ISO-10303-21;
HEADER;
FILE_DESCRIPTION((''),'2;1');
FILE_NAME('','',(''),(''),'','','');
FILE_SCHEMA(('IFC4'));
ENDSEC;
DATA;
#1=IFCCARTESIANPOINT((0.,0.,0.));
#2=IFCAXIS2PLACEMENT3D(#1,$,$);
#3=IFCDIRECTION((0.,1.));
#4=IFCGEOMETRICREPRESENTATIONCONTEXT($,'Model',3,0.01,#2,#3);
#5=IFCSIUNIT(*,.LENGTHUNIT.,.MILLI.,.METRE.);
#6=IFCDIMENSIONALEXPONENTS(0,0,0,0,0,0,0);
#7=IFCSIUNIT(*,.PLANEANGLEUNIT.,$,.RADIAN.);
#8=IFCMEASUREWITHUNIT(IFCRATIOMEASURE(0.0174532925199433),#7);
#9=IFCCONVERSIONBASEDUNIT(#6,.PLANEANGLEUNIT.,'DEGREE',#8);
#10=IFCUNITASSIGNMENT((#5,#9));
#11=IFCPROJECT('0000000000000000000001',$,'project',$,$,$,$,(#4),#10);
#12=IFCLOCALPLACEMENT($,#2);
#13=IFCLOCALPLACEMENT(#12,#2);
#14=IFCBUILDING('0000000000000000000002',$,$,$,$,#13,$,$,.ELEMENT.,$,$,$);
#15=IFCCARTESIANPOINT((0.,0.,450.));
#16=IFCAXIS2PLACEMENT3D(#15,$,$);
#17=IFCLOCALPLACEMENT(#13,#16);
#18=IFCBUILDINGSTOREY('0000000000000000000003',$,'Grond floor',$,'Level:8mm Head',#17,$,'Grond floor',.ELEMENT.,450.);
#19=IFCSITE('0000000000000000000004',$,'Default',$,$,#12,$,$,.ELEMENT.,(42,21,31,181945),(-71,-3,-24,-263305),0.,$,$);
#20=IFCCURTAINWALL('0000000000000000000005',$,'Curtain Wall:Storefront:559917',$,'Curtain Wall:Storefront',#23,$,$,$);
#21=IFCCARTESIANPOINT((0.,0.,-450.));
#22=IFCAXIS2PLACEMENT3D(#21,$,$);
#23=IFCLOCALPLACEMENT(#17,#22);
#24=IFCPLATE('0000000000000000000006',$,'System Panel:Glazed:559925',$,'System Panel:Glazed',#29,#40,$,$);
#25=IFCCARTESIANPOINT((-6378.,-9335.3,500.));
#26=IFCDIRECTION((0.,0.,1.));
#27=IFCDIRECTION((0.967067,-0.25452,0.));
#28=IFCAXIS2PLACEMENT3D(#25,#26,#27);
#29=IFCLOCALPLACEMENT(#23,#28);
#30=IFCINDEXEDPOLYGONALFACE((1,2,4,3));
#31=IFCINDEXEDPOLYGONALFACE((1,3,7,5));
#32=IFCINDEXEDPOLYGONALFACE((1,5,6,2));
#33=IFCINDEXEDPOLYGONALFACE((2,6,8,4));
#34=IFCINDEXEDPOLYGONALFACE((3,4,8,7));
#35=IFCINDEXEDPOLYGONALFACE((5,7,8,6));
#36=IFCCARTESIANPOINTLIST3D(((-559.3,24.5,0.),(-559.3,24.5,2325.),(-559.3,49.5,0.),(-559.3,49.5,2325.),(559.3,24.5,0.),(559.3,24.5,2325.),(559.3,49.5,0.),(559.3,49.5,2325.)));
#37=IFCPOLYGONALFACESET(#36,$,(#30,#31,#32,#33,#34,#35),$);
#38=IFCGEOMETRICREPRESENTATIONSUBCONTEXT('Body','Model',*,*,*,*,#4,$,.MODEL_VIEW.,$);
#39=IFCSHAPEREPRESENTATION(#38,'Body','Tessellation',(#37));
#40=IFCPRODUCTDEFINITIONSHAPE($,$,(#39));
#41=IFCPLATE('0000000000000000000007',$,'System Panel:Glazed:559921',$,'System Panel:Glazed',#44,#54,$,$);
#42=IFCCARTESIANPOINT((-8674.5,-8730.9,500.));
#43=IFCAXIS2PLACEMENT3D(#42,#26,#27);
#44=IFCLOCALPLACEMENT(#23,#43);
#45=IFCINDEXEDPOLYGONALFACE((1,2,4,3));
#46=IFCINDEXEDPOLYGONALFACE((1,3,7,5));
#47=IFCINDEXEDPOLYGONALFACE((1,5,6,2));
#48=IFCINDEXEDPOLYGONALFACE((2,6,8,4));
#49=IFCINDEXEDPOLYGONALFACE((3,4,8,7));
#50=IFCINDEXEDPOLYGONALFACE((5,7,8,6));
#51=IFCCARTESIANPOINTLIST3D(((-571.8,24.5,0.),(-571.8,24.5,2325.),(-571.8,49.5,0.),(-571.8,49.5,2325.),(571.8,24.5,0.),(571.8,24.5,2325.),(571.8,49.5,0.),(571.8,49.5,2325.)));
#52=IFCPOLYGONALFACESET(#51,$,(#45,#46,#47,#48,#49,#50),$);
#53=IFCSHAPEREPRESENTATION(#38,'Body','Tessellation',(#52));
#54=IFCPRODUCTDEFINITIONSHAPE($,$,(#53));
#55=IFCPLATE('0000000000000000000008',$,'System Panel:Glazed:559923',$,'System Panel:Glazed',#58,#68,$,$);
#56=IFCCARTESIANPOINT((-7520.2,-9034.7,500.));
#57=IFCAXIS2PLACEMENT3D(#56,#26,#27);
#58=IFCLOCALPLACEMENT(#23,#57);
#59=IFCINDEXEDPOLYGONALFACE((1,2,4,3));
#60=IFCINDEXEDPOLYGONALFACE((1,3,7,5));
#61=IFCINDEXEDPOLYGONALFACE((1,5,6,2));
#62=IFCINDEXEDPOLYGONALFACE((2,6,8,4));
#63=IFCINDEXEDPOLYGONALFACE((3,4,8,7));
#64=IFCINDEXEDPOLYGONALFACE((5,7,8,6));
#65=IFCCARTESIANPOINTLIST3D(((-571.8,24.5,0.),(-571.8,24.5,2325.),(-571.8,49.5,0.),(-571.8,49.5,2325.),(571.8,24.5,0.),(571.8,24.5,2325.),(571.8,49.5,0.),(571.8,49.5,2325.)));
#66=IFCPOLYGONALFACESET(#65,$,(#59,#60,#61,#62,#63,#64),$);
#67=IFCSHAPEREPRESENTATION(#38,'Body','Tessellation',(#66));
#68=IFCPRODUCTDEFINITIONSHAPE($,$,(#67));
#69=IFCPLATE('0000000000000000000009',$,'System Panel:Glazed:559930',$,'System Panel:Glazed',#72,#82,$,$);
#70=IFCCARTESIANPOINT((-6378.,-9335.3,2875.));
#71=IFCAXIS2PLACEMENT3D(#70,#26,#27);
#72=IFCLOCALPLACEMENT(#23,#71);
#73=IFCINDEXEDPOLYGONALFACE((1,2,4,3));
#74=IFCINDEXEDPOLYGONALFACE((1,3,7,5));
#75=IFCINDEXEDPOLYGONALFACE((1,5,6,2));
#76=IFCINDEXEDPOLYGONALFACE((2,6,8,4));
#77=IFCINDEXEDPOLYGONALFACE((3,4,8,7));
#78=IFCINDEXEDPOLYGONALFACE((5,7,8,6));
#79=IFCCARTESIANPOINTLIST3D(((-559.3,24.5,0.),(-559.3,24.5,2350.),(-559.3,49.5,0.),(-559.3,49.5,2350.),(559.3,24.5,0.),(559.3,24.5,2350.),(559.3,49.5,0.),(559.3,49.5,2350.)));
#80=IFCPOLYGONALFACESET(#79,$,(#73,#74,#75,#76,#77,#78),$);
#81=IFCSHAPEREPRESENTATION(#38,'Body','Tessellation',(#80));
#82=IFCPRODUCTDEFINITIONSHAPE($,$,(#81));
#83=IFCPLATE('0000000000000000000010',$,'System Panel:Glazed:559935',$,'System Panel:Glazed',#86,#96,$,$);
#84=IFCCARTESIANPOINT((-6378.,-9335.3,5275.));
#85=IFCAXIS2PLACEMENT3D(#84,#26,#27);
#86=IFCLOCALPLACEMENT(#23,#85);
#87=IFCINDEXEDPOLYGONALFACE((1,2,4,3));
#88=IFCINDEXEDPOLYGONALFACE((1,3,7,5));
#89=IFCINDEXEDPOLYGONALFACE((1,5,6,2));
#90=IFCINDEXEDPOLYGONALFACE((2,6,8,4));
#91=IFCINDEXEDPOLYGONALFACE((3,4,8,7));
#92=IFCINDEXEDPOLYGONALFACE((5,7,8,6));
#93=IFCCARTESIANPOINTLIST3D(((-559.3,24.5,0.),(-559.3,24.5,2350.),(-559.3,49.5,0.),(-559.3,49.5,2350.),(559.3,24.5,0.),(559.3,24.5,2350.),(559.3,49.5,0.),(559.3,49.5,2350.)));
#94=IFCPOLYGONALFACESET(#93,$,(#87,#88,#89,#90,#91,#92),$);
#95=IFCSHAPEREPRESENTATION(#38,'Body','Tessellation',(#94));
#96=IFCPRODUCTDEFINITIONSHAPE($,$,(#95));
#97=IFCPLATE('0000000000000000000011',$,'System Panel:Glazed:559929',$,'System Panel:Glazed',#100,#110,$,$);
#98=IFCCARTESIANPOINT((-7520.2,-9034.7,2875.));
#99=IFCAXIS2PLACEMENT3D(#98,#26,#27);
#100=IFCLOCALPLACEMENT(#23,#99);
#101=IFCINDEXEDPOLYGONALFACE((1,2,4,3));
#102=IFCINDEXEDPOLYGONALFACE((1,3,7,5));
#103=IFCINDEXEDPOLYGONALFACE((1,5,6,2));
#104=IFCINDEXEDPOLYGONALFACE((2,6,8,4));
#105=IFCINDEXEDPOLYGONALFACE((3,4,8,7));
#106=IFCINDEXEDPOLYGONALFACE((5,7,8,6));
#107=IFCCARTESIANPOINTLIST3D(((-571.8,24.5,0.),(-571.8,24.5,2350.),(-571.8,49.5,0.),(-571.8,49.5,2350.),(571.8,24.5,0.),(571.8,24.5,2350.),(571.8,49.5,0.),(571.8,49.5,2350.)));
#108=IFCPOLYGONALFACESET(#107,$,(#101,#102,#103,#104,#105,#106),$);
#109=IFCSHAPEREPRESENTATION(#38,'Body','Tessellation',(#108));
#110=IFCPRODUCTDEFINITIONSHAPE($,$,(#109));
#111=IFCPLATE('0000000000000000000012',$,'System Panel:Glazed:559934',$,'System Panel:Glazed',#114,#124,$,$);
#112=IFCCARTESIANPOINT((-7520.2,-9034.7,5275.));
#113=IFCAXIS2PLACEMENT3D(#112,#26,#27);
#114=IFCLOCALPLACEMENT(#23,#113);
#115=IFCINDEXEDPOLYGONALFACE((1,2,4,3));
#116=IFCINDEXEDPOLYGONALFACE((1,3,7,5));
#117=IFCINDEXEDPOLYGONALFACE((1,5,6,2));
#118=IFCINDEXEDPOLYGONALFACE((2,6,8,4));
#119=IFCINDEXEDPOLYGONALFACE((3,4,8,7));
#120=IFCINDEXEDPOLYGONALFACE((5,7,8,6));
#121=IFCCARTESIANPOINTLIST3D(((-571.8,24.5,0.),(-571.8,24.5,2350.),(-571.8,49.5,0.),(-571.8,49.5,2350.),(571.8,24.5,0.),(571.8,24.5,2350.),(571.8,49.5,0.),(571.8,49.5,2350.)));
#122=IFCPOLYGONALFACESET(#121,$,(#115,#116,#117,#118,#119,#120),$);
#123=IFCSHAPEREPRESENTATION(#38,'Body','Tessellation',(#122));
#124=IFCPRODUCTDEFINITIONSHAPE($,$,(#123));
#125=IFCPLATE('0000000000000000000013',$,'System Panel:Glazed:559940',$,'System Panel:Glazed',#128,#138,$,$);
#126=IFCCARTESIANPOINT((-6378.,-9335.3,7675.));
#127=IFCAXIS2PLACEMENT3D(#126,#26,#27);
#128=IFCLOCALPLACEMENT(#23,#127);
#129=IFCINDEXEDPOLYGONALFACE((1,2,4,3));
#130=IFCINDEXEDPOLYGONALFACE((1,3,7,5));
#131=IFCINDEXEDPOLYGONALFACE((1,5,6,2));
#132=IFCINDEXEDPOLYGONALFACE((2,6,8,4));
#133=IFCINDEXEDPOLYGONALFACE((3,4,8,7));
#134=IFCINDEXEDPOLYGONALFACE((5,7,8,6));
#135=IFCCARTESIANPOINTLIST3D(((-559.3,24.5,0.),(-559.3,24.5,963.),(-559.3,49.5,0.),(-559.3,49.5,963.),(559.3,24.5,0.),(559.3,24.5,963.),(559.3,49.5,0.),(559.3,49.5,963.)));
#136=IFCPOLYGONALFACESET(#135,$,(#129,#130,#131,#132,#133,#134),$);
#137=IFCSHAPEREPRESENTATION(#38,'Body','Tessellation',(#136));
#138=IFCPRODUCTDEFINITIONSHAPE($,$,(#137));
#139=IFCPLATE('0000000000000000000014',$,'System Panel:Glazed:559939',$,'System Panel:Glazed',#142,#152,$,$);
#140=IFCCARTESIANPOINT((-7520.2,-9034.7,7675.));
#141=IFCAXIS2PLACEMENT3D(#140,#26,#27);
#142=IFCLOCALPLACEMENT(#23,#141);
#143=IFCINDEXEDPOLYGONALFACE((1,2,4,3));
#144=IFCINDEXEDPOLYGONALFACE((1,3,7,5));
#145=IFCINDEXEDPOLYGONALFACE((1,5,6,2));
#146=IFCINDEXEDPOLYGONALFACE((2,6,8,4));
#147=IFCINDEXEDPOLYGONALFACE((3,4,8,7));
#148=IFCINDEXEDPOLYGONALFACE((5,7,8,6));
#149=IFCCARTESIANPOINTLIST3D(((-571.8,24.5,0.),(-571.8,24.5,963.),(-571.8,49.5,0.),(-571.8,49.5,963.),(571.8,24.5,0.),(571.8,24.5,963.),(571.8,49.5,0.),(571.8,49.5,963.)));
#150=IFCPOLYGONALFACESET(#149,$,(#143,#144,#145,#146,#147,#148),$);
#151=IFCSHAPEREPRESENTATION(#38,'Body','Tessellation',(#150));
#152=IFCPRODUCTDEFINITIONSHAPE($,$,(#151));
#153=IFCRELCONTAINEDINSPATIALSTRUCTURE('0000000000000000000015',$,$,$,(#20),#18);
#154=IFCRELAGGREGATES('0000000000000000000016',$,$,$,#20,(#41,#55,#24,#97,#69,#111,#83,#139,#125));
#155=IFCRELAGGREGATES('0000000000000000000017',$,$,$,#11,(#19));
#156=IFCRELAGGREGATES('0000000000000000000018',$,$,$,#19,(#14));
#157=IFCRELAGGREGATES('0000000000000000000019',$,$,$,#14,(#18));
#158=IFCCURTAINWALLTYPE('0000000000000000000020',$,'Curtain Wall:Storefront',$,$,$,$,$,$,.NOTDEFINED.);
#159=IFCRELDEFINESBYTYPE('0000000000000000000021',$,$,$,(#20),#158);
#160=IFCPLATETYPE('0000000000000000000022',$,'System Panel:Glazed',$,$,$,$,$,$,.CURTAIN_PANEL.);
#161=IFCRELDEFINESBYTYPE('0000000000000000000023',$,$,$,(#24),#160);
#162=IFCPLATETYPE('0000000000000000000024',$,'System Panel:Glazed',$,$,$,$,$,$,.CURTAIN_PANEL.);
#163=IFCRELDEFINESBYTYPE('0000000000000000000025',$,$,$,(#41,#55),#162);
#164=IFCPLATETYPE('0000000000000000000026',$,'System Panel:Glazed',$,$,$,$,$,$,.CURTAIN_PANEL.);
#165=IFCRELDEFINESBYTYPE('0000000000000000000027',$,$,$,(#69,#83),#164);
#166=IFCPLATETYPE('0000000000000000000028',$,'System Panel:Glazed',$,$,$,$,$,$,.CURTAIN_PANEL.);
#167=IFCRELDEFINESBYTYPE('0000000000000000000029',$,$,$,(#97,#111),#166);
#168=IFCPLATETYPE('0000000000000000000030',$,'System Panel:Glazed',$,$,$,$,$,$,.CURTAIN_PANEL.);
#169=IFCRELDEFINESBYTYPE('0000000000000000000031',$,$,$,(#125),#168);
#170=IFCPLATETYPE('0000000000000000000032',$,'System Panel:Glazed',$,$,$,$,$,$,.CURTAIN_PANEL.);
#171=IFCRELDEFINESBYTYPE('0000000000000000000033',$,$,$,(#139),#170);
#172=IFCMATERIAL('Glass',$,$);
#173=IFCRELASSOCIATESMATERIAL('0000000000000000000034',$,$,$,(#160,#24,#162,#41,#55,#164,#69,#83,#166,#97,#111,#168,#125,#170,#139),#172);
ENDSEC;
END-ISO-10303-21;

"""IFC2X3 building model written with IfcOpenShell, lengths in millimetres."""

from ifc_helpers import new_model, entity, si_unit, converted_unit, direction, frame, frame_2d, origin, place, context, subcontext, project, spatial, rectangle, extrude, source, transform, mapped, material, type_object, type_shapes, element, aggregate, save


model = new_model("IFC2X3")

# Units and contexts
model_context = context("Model", 3, precision=0.01, world=origin(), true_north=direction((0.0, 1.0)))
body_context = subcontext(model_context, "Body", "Model", "MODEL_VIEW")
ifc_project = project(units=[si_unit("LENGTHUNIT", "METRE", prefix="MILLI"), converted_unit("PLANEANGLEUNIT", "DEGREE", entity("IfcRatioMeasure", 0.0174532925199433), si_unit("PLANEANGLEUNIT", "RADIAN"), dimensions=[0, 0, 0, 0, 0, 0, 0])], contexts=[model_context])

# Site, building, storey
site_placement = place(None, origin())
site = spatial("IfcSite", under=ifc_project, at=site_placement, Name="Default", CompositionType="ELEMENT", RefLatitude=(42, 21, 31, 181945), RefLongitude=(-71, -3, -24, -263305), RefElevation=0.0)
building_placement = place(site_placement, origin())
building = spatial("IfcBuilding", under=site, at=building_placement, CompositionType="ELEMENT")
storey_placement = place(building_placement, frame((0.0, 0.0, 450.0)))
storey = spatial("IfcBuildingStorey", under=building, at=storey_placement, Name="Grond floor", ObjectType="Level:8mm Head", LongName="Grond floor", CompositionType="ELEMENT", Elevation=450.0)

# Curtain wall
curtain_wall_type = type_object("IfcCurtainWallType", Name="Curtain Wall:Storefront", PredefinedType="NOTDEFINED")
curtain_wall_placement = place(storey_placement, frame((0.0, 0.0, -450.0)))
curtain_wall = element("IfcCurtainWall", 1, at=curtain_wall_placement, inside=storey, type_object=curtain_wall_type, Name="Curtain Wall:Storefront:559917", ObjectType="Curtain Wall:Storefront")

# Plates
ifc_material_1 = material(Name="Glass")
plate_type_1 = type_object("IfcPlateType", Name="System Panel:Glazed", PredefinedType="CURTAIN_PANEL", material=ifc_material_1)
shared_shape_1 = source(origin(), body_context, "Body", "SweptSolid", [
    extrude(rectangle(XDim=25.0, YDim=1118.6, at=frame_2d((0.0, 0.0), x_axis=(1.0, 0.0))), frame((0.0, 37.0, 0.0), z_axis=(0.0, 0.0, 1.0), x_axis=(0.0, 1.0, 0.0)), (0.0, 0.0, 1.0), 2325.0),
])
type_shapes(plate_type_1, [shared_shape_1])
plate_1_placement = place(curtain_wall_placement, frame((-6378.0, -9335.3, 500.0), z_axis=(0.0, 0.0, 1.0), x_axis=(0.967067, -0.25452, 0.0)))
plate_1 = element("IfcPlate", 2, at=plate_1_placement, type_object=plate_type_1, material=ifc_material_1, Name="System Panel:Glazed:559925", ObjectType="System Panel:Glazed", context=body_context, shape_type="MappedRepresentation", body=[
    mapped(shared_shape_1, transform((0.0, 0.0, 0.0), scale=1.0)),
])
plate_type_2 = type_object("IfcPlateType", Name="System Panel:Glazed", PredefinedType="CURTAIN_PANEL", material=ifc_material_1)
shared_shape_2 = source(origin(), body_context, "Body", "SweptSolid", [
    extrude(rectangle(XDim=25.0, YDim=1143.6, at=frame_2d((0.0, 0.0), x_axis=(1.0, 0.0))), frame((0.0, 37.0, 0.0), z_axis=(0.0, 0.0, 1.0), x_axis=(0.0, 1.0, 0.0)), (0.0, 0.0, 1.0), 2325.0),
])
type_shapes(plate_type_2, [shared_shape_2])
plate_2_placement = place(curtain_wall_placement, frame((-8674.5, -8730.9, 500.0), z_axis=(0.0, 0.0, 1.0), x_axis=(0.967067, -0.25452, 0.0)))
plate_2 = element("IfcPlate", 3, at=plate_2_placement, type_object=plate_type_2, material=ifc_material_1, Name="System Panel:Glazed:559921", ObjectType="System Panel:Glazed", context=body_context, shape_type="MappedRepresentation", body=[
    mapped(shared_shape_2, transform((0.0, 0.0, 0.0), scale=1.0)),
])
plate_3_placement = place(curtain_wall_placement, frame((-7520.2, -9034.7, 500.0), z_axis=(0.0, 0.0, 1.0), x_axis=(0.967067, -0.25452, 0.0)))
plate_3 = element("IfcPlate", 4, at=plate_3_placement, type_object=plate_type_2, material=ifc_material_1, Name="System Panel:Glazed:559923", ObjectType="System Panel:Glazed", context=body_context, shape_type="MappedRepresentation", body=[
    mapped(shared_shape_2, transform((0.0, 0.0, 0.0), scale=1.0)),
])
plate_type_3 = type_object("IfcPlateType", Name="System Panel:Glazed", PredefinedType="CURTAIN_PANEL", material=ifc_material_1)
shared_shape_3 = source(origin(), body_context, "Body", "SweptSolid", [
    extrude(rectangle(XDim=25.0, YDim=1118.6, at=frame_2d((0.0, 0.0), x_axis=(1.0, 0.0))), frame((0.0, 37.0, 0.0), z_axis=(0.0, 0.0, 1.0), x_axis=(0.0, 1.0, 0.0)), (0.0, 0.0, 1.0), 2350.0),
])
type_shapes(plate_type_3, [shared_shape_3])
plate_4_placement = place(curtain_wall_placement, frame((-6378.0, -9335.3, 2875.0), z_axis=(0.0, 0.0, 1.0), x_axis=(0.967067, -0.25452, 0.0)))
plate_4 = element("IfcPlate", 5, at=plate_4_placement, type_object=plate_type_3, material=ifc_material_1, Name="System Panel:Glazed:559930", ObjectType="System Panel:Glazed", context=body_context, shape_type="MappedRepresentation", body=[
    mapped(shared_shape_3, transform((0.0, 0.0, 0.0), scale=1.0)),
])
plate_5_placement = place(curtain_wall_placement, frame((-6378.0, -9335.3, 5275.0), z_axis=(0.0, 0.0, 1.0), x_axis=(0.967067, -0.25452, 0.0)))
plate_5 = element("IfcPlate", 6, at=plate_5_placement, type_object=plate_type_3, material=ifc_material_1, Name="System Panel:Glazed:559935", ObjectType="System Panel:Glazed", context=body_context, shape_type="MappedRepresentation", body=[
    mapped(shared_shape_3, transform((0.0, 0.0, 0.0), scale=1.0)),
])
plate_type_4 = type_object("IfcPlateType", Name="System Panel:Glazed", PredefinedType="CURTAIN_PANEL", material=ifc_material_1)
shared_shape_4 = source(origin(), body_context, "Body", "SweptSolid", [
    extrude(rectangle(XDim=25.0, YDim=1143.6, at=frame_2d((0.0, 0.0), x_axis=(1.0, 0.0))), frame((0.0, 37.0, 0.0), z_axis=(0.0, 0.0, 1.0), x_axis=(0.0, 1.0, 0.0)), (0.0, 0.0, 1.0), 2350.0),
])
type_shapes(plate_type_4, [shared_shape_4])
plate_6_placement = place(curtain_wall_placement, frame((-7520.2, -9034.7, 2875.0), z_axis=(0.0, 0.0, 1.0), x_axis=(0.967067, -0.25452, 0.0)))
plate_6 = element("IfcPlate", 7, at=plate_6_placement, type_object=plate_type_4, material=ifc_material_1, Name="System Panel:Glazed:559929", ObjectType="System Panel:Glazed", context=body_context, shape_type="MappedRepresentation", body=[
    mapped(shared_shape_4, transform((0.0, 0.0, 0.0), scale=1.0)),
])
plate_7_placement = place(curtain_wall_placement, frame((-7520.2, -9034.7, 5275.0), z_axis=(0.0, 0.0, 1.0), x_axis=(0.967067, -0.25452, 0.0)))
plate_7 = element("IfcPlate", 8, at=plate_7_placement, type_object=plate_type_4, material=ifc_material_1, Name="System Panel:Glazed:559934", ObjectType="System Panel:Glazed", context=body_context, shape_type="MappedRepresentation", body=[
    mapped(shared_shape_4, transform((0.0, 0.0, 0.0), scale=1.0)),
])
plate_type_5 = type_object("IfcPlateType", Name="System Panel:Glazed", PredefinedType="CURTAIN_PANEL", material=ifc_material_1)
shared_shape_5 = source(origin(), body_context, "Body", "SweptSolid", [
    extrude(rectangle(XDim=25.0, YDim=1118.6, at=frame_2d((0.0, 0.0), x_axis=(1.0, 0.0))), frame((0.0, 37.0, 0.0), z_axis=(0.0, 0.0, 1.0), x_axis=(0.0, 1.0, 0.0)), (0.0, 0.0, 1.0), 963.0),
])
type_shapes(plate_type_5, [shared_shape_5])
plate_8_placement = place(curtain_wall_placement, frame((-6378.0, -9335.3, 7675.0), z_axis=(0.0, 0.0, 1.0), x_axis=(0.967067, -0.25452, 0.0)))
plate_8 = element("IfcPlate", 9, at=plate_8_placement, type_object=plate_type_5, material=ifc_material_1, Name="System Panel:Glazed:559940", ObjectType="System Panel:Glazed", context=body_context, shape_type="MappedRepresentation", body=[
    mapped(shared_shape_5, transform((0.0, 0.0, 0.0), scale=1.0)),
])
plate_type_6 = type_object("IfcPlateType", Name="System Panel:Glazed", PredefinedType="CURTAIN_PANEL", material=ifc_material_1)
shared_shape_6 = source(origin(), body_context, "Body", "SweptSolid", [
    extrude(rectangle(XDim=25.0, YDim=1143.6, at=frame_2d((0.0, 0.0), x_axis=(1.0, 0.0))), frame((0.0, 37.0, 0.0), z_axis=(0.0, 0.0, 1.0), x_axis=(0.0, 1.0, 0.0)), (0.0, 0.0, 1.0), 963.0),
])
type_shapes(plate_type_6, [shared_shape_6])
plate_9_placement = place(curtain_wall_placement, frame((-7520.2, -9034.7, 7675.0), z_axis=(0.0, 0.0, 1.0), x_axis=(0.967067, -0.25452, 0.0)))
plate_9 = element("IfcPlate", 10, at=plate_9_placement, type_object=plate_type_6, material=ifc_material_1, Name="System Panel:Glazed:559939", ObjectType="System Panel:Glazed", context=body_context, shape_type="MappedRepresentation", body=[
    mapped(shared_shape_6, transform((0.0, 0.0, 0.0), scale=1.0)),
])
aggregate(curtain_wall, [plate_2, plate_3, plate_1, plate_6, plate_4, plate_7, plate_5, plate_9, plate_8])

save(model, "model.ifc")
